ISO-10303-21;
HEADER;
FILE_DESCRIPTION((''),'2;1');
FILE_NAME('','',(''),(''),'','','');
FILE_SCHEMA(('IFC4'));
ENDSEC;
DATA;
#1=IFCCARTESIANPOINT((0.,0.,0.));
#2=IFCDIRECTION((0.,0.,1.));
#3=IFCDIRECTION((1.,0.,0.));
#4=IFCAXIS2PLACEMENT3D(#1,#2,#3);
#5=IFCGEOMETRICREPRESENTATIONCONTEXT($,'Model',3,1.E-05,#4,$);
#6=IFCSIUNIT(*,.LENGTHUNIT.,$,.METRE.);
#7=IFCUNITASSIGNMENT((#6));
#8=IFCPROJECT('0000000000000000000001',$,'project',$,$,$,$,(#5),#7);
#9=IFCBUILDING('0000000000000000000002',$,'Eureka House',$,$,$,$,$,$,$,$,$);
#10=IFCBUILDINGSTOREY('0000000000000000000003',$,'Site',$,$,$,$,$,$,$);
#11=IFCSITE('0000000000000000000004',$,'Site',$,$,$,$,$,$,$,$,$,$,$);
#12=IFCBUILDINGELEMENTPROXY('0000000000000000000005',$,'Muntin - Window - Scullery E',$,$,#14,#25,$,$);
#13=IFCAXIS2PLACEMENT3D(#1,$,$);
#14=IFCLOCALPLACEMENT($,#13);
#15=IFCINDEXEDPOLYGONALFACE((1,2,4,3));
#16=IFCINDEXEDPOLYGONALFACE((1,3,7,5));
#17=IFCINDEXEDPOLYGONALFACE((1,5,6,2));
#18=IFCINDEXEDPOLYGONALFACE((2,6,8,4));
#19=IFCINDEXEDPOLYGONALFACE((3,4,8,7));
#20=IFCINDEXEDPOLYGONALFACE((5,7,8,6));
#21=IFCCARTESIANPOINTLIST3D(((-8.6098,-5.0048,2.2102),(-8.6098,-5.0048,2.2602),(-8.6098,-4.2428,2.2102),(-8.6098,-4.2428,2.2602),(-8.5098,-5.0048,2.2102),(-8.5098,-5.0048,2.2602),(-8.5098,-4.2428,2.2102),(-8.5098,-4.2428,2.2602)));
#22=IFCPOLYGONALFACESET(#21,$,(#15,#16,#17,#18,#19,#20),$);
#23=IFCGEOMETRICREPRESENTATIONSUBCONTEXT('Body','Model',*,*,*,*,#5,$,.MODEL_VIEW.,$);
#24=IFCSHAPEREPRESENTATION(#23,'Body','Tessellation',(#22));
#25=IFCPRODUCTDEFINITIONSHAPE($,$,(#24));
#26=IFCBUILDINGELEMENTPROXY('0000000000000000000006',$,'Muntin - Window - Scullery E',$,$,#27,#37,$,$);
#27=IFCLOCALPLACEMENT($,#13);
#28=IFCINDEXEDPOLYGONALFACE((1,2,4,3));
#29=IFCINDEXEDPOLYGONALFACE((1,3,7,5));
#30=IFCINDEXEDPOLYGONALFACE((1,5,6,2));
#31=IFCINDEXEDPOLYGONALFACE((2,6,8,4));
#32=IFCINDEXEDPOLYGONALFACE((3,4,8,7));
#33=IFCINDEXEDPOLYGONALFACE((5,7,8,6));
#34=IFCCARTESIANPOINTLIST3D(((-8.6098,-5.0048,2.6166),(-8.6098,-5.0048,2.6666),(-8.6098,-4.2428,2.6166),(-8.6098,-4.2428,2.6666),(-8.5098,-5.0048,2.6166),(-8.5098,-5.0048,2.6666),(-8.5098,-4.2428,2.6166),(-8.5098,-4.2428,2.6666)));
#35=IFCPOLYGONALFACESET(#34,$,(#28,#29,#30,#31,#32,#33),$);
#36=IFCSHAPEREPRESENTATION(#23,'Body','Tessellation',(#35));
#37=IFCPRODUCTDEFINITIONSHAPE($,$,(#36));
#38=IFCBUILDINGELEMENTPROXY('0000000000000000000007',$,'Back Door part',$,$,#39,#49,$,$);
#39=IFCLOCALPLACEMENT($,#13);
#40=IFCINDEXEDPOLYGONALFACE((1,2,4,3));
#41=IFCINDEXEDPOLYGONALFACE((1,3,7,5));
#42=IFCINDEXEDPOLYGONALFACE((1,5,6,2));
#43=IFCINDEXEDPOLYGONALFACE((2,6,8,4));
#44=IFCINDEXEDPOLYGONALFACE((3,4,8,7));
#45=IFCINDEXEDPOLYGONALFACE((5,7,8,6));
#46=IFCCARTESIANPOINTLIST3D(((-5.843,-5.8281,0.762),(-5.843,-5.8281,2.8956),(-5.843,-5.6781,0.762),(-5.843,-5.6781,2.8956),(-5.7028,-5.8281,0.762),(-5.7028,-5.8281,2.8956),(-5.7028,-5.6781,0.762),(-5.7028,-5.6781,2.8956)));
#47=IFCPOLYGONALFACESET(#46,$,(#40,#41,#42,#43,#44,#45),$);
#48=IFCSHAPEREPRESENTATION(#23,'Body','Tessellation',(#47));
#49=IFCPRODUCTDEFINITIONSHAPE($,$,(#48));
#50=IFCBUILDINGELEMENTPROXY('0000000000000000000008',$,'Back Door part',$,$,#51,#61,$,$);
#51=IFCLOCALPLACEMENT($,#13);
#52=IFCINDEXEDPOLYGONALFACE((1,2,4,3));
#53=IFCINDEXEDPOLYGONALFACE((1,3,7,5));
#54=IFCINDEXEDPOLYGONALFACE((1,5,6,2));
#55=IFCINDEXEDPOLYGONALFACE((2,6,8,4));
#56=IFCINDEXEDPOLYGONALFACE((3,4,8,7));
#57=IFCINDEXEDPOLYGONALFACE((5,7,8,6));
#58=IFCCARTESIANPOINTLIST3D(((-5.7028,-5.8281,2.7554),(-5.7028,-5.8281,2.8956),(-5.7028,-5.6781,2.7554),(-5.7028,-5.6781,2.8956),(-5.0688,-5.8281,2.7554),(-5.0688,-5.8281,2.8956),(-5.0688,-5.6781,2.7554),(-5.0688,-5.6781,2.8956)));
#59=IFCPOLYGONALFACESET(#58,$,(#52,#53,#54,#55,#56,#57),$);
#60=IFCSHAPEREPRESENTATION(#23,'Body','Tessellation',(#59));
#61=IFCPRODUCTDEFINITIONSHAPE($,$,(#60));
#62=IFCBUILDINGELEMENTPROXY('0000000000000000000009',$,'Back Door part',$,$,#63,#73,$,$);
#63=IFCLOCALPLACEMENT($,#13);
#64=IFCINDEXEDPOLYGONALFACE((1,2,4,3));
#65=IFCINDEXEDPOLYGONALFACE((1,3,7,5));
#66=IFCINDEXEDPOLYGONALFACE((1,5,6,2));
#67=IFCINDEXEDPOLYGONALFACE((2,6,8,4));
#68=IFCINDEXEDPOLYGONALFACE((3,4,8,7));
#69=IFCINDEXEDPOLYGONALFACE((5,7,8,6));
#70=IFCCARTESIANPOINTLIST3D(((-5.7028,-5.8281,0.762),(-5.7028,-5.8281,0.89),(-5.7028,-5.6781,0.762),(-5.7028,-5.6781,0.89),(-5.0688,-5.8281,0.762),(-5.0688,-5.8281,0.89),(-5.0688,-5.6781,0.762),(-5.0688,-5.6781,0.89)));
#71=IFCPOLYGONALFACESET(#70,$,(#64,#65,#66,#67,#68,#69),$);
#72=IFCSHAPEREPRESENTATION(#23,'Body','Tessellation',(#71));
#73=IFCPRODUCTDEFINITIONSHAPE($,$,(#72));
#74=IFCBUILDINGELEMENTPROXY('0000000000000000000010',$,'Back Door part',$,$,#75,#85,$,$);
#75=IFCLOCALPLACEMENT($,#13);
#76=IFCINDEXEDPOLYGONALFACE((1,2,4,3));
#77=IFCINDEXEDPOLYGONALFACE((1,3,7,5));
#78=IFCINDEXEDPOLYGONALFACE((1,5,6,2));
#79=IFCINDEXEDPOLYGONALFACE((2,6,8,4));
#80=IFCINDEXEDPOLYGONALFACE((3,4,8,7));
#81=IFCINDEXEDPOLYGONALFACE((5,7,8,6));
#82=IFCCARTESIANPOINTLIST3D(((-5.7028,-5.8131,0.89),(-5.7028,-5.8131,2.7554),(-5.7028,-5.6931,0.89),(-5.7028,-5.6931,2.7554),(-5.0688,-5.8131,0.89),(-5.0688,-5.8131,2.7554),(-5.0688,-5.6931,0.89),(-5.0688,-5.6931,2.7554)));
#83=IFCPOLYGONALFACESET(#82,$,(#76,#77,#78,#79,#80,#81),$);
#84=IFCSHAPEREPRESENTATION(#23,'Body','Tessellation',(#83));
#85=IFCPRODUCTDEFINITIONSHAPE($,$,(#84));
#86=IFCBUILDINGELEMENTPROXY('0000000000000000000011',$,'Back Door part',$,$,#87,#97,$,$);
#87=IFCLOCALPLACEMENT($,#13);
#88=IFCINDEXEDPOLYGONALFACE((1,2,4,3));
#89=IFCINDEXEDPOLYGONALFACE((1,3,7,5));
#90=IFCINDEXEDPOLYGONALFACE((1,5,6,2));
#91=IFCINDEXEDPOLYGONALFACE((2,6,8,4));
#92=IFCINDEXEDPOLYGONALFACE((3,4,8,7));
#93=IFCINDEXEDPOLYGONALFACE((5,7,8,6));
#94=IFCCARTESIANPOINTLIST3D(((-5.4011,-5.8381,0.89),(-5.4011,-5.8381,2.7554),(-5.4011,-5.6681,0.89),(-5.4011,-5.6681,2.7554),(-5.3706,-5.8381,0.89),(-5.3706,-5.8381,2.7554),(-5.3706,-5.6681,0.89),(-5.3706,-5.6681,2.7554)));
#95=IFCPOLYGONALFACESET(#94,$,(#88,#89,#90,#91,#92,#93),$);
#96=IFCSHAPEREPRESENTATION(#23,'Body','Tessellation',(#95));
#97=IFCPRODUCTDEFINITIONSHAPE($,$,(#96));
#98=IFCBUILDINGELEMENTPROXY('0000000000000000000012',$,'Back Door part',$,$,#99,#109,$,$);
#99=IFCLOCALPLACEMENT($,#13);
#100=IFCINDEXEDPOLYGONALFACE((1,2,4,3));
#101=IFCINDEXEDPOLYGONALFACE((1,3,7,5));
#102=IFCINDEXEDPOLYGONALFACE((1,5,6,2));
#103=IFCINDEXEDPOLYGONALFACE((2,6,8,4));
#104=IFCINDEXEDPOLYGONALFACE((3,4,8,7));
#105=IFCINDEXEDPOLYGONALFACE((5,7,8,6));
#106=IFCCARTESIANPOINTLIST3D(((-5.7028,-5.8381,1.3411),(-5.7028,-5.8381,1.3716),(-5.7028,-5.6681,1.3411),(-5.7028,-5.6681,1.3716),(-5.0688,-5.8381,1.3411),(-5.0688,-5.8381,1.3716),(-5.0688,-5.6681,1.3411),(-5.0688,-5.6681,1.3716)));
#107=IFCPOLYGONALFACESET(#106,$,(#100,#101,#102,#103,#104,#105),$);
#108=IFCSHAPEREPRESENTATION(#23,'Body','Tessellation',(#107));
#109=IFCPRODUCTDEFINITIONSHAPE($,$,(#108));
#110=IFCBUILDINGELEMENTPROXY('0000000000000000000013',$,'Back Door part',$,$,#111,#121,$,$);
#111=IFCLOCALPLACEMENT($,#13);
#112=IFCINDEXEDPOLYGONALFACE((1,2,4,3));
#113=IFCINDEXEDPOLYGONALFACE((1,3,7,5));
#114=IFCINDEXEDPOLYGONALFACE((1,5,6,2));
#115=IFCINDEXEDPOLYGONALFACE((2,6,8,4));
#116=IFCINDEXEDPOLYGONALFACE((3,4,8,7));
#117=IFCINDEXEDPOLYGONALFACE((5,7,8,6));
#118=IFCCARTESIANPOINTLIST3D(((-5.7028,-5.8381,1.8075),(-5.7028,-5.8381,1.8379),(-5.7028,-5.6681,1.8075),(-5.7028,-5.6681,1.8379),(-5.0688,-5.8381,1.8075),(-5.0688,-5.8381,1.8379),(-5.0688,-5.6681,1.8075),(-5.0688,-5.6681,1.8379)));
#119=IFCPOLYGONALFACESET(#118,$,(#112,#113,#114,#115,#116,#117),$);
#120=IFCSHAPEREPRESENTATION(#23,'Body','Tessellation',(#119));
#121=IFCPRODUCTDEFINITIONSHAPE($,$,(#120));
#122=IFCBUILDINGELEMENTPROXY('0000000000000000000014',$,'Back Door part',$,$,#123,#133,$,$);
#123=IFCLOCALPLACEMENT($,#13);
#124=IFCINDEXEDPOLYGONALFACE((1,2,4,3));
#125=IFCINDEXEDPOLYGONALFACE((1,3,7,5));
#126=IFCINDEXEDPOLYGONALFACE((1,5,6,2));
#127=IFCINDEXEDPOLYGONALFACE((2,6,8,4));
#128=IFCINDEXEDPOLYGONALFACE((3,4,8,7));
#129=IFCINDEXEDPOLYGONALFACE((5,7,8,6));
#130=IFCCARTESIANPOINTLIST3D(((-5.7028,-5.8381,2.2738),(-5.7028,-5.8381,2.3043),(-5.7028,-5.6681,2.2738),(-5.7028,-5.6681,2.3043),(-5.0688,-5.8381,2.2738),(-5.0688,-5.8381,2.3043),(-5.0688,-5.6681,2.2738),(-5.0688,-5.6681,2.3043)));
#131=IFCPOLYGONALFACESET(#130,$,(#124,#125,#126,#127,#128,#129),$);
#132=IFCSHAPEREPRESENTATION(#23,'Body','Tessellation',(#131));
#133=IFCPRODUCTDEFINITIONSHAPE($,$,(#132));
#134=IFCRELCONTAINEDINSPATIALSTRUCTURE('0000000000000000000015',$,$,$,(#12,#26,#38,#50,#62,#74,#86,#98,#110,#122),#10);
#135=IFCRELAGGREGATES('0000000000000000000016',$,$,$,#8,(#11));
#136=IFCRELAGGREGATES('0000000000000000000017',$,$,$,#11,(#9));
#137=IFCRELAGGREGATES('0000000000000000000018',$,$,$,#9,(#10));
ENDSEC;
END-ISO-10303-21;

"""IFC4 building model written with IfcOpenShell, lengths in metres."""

from ifc_helpers import new_model, si_unit, frame, origin, origin_with_axes, origin_2d, place, context, subcontext, project, spatial, rectangle, extrude, element, save


model = new_model("IFC4")

# Units and contexts
model_context = context("Model", 3, precision=1e-05, world=origin_with_axes())
body_context = subcontext(model_context, "Body", "Model", "MODEL_VIEW")
ifc_project = project(units=[si_unit("LENGTHUNIT", "METRE")], contexts=[model_context])

# Site, building, storey
site = spatial("IfcSite", under=ifc_project, Name="Site")
building = spatial("IfcBuilding", under=site, Name="Eureka House")
storey = spatial("IfcBuildingStorey", under=building, Name="Site")

# Building element proxies
for number, where, z_axis, x_axis, name in (
    (1, (-8.5598, -4.6238, 2.2102), (0.0, 0.0, 1.0), (1.0, 0.0, 0.0), "Muntin - Window - Scullery E"),
    (2, (-8.5598, -4.6238, 2.6166), (0.0, 0.0, 1.0), (1.0, 0.0, 0.0), "Muntin - Window - Scullery E"),
):
    element("IfcBuildingElementProxy", number, at=place(None, frame(where, z_axis=z_axis, x_axis=x_axis)), inside=storey, Name=name, context=body_context, shape_type="SweptSolid", body=[
        extrude(rectangle(XDim=0.1, YDim=0.762, at=origin_2d()), origin(), (0.0, 0.0, 1.0), 0.05),
    ])
proxy_1_placement = place(None, frame((-5.7729, -5.7531, 0.762), z_axis=(0.0, 0.0, 1.0), x_axis=(1.0, 0.0, 0.0)))
element("IfcBuildingElementProxy", 3, at=proxy_1_placement, inside=storey, Name="Back Door part", context=body_context, shape_type="SweptSolid", body=[
    extrude(rectangle(XDim=0.1402, YDim=0.15, at=origin_2d()), origin(), (0.0, 0.0, 1.0), 2.1336),
])
proxy_2_placement = place(None, frame((-5.3858, -5.7531, 2.7554), z_axis=(0.0, 0.0, 1.0), x_axis=(1.0, 0.0, 0.0)))
element("IfcBuildingElementProxy", 4, at=proxy_2_placement, inside=storey, Name="Back Door part", context=body_context, shape_type="SweptSolid", body=[
    extrude(rectangle(XDim=0.634, YDim=0.15, at=origin_2d()), origin(), (0.0, 0.0, 1.0), 0.1402),
])
proxy_3_placement = place(None, frame((-5.3858, -5.7531, 0.762), z_axis=(0.0, 0.0, 1.0), x_axis=(1.0, 0.0, 0.0)))
element("IfcBuildingElementProxy", 5, at=proxy_3_placement, inside=storey, Name="Back Door part", context=body_context, shape_type="SweptSolid", body=[
    extrude(rectangle(XDim=0.634, YDim=0.15, at=origin_2d()), origin(), (0.0, 0.0, 1.0), 0.128),
])
proxy_4_placement = place(None, frame((-5.3858, -5.7531, 0.89), z_axis=(0.0, 0.0, 1.0), x_axis=(1.0, 0.0, 0.0)))
element("IfcBuildingElementProxy", 6, at=proxy_4_placement, inside=storey, Name="Back Door part", context=body_context, shape_type="SweptSolid", body=[
    extrude(rectangle(XDim=0.634, YDim=0.12, at=origin_2d()), origin(), (0.0, 0.0, 1.0), 1.8654),
])
proxy_5_placement = place(None, frame((-5.3858, -5.7531, 0.89), z_axis=(0.0, 0.0, 1.0), x_axis=(1.0, 0.0, 0.0)))
element("IfcBuildingElementProxy", 7, at=proxy_5_placement, inside=storey, Name="Back Door part", context=body_context, shape_type="SweptSolid", body=[
    extrude(rectangle(XDim=0.0305, YDim=0.17, at=origin_2d()), origin(), (0.0, 0.0, 1.0), 1.8654),
])
for number, where, z_axis, x_axis, name in (
    (8, (-5.3858, -5.7531, 1.3411), (0.0, 0.0, 1.0), (1.0, 0.0, 0.0), "Back Door part"),
    (9, (-5.3858, -5.7531, 1.8075), (0.0, 0.0, 1.0), (1.0, 0.0, 0.0), "Back Door part"),
    (10, (-5.3858, -5.7531, 2.2738), (0.0, 0.0, 1.0), (1.0, 0.0, 0.0), "Back Door part"),
):
    element("IfcBuildingElementProxy", number, at=place(None, frame(where, z_axis=z_axis, x_axis=x_axis)), inside=storey, Name=name, context=body_context, shape_type="SweptSolid", body=[
        extrude(rectangle(XDim=0.634, YDim=0.17, at=origin_2d()), origin(), (0.0, 0.0, 1.0), 0.0305),
    ])

save(model, "model.ifc")
